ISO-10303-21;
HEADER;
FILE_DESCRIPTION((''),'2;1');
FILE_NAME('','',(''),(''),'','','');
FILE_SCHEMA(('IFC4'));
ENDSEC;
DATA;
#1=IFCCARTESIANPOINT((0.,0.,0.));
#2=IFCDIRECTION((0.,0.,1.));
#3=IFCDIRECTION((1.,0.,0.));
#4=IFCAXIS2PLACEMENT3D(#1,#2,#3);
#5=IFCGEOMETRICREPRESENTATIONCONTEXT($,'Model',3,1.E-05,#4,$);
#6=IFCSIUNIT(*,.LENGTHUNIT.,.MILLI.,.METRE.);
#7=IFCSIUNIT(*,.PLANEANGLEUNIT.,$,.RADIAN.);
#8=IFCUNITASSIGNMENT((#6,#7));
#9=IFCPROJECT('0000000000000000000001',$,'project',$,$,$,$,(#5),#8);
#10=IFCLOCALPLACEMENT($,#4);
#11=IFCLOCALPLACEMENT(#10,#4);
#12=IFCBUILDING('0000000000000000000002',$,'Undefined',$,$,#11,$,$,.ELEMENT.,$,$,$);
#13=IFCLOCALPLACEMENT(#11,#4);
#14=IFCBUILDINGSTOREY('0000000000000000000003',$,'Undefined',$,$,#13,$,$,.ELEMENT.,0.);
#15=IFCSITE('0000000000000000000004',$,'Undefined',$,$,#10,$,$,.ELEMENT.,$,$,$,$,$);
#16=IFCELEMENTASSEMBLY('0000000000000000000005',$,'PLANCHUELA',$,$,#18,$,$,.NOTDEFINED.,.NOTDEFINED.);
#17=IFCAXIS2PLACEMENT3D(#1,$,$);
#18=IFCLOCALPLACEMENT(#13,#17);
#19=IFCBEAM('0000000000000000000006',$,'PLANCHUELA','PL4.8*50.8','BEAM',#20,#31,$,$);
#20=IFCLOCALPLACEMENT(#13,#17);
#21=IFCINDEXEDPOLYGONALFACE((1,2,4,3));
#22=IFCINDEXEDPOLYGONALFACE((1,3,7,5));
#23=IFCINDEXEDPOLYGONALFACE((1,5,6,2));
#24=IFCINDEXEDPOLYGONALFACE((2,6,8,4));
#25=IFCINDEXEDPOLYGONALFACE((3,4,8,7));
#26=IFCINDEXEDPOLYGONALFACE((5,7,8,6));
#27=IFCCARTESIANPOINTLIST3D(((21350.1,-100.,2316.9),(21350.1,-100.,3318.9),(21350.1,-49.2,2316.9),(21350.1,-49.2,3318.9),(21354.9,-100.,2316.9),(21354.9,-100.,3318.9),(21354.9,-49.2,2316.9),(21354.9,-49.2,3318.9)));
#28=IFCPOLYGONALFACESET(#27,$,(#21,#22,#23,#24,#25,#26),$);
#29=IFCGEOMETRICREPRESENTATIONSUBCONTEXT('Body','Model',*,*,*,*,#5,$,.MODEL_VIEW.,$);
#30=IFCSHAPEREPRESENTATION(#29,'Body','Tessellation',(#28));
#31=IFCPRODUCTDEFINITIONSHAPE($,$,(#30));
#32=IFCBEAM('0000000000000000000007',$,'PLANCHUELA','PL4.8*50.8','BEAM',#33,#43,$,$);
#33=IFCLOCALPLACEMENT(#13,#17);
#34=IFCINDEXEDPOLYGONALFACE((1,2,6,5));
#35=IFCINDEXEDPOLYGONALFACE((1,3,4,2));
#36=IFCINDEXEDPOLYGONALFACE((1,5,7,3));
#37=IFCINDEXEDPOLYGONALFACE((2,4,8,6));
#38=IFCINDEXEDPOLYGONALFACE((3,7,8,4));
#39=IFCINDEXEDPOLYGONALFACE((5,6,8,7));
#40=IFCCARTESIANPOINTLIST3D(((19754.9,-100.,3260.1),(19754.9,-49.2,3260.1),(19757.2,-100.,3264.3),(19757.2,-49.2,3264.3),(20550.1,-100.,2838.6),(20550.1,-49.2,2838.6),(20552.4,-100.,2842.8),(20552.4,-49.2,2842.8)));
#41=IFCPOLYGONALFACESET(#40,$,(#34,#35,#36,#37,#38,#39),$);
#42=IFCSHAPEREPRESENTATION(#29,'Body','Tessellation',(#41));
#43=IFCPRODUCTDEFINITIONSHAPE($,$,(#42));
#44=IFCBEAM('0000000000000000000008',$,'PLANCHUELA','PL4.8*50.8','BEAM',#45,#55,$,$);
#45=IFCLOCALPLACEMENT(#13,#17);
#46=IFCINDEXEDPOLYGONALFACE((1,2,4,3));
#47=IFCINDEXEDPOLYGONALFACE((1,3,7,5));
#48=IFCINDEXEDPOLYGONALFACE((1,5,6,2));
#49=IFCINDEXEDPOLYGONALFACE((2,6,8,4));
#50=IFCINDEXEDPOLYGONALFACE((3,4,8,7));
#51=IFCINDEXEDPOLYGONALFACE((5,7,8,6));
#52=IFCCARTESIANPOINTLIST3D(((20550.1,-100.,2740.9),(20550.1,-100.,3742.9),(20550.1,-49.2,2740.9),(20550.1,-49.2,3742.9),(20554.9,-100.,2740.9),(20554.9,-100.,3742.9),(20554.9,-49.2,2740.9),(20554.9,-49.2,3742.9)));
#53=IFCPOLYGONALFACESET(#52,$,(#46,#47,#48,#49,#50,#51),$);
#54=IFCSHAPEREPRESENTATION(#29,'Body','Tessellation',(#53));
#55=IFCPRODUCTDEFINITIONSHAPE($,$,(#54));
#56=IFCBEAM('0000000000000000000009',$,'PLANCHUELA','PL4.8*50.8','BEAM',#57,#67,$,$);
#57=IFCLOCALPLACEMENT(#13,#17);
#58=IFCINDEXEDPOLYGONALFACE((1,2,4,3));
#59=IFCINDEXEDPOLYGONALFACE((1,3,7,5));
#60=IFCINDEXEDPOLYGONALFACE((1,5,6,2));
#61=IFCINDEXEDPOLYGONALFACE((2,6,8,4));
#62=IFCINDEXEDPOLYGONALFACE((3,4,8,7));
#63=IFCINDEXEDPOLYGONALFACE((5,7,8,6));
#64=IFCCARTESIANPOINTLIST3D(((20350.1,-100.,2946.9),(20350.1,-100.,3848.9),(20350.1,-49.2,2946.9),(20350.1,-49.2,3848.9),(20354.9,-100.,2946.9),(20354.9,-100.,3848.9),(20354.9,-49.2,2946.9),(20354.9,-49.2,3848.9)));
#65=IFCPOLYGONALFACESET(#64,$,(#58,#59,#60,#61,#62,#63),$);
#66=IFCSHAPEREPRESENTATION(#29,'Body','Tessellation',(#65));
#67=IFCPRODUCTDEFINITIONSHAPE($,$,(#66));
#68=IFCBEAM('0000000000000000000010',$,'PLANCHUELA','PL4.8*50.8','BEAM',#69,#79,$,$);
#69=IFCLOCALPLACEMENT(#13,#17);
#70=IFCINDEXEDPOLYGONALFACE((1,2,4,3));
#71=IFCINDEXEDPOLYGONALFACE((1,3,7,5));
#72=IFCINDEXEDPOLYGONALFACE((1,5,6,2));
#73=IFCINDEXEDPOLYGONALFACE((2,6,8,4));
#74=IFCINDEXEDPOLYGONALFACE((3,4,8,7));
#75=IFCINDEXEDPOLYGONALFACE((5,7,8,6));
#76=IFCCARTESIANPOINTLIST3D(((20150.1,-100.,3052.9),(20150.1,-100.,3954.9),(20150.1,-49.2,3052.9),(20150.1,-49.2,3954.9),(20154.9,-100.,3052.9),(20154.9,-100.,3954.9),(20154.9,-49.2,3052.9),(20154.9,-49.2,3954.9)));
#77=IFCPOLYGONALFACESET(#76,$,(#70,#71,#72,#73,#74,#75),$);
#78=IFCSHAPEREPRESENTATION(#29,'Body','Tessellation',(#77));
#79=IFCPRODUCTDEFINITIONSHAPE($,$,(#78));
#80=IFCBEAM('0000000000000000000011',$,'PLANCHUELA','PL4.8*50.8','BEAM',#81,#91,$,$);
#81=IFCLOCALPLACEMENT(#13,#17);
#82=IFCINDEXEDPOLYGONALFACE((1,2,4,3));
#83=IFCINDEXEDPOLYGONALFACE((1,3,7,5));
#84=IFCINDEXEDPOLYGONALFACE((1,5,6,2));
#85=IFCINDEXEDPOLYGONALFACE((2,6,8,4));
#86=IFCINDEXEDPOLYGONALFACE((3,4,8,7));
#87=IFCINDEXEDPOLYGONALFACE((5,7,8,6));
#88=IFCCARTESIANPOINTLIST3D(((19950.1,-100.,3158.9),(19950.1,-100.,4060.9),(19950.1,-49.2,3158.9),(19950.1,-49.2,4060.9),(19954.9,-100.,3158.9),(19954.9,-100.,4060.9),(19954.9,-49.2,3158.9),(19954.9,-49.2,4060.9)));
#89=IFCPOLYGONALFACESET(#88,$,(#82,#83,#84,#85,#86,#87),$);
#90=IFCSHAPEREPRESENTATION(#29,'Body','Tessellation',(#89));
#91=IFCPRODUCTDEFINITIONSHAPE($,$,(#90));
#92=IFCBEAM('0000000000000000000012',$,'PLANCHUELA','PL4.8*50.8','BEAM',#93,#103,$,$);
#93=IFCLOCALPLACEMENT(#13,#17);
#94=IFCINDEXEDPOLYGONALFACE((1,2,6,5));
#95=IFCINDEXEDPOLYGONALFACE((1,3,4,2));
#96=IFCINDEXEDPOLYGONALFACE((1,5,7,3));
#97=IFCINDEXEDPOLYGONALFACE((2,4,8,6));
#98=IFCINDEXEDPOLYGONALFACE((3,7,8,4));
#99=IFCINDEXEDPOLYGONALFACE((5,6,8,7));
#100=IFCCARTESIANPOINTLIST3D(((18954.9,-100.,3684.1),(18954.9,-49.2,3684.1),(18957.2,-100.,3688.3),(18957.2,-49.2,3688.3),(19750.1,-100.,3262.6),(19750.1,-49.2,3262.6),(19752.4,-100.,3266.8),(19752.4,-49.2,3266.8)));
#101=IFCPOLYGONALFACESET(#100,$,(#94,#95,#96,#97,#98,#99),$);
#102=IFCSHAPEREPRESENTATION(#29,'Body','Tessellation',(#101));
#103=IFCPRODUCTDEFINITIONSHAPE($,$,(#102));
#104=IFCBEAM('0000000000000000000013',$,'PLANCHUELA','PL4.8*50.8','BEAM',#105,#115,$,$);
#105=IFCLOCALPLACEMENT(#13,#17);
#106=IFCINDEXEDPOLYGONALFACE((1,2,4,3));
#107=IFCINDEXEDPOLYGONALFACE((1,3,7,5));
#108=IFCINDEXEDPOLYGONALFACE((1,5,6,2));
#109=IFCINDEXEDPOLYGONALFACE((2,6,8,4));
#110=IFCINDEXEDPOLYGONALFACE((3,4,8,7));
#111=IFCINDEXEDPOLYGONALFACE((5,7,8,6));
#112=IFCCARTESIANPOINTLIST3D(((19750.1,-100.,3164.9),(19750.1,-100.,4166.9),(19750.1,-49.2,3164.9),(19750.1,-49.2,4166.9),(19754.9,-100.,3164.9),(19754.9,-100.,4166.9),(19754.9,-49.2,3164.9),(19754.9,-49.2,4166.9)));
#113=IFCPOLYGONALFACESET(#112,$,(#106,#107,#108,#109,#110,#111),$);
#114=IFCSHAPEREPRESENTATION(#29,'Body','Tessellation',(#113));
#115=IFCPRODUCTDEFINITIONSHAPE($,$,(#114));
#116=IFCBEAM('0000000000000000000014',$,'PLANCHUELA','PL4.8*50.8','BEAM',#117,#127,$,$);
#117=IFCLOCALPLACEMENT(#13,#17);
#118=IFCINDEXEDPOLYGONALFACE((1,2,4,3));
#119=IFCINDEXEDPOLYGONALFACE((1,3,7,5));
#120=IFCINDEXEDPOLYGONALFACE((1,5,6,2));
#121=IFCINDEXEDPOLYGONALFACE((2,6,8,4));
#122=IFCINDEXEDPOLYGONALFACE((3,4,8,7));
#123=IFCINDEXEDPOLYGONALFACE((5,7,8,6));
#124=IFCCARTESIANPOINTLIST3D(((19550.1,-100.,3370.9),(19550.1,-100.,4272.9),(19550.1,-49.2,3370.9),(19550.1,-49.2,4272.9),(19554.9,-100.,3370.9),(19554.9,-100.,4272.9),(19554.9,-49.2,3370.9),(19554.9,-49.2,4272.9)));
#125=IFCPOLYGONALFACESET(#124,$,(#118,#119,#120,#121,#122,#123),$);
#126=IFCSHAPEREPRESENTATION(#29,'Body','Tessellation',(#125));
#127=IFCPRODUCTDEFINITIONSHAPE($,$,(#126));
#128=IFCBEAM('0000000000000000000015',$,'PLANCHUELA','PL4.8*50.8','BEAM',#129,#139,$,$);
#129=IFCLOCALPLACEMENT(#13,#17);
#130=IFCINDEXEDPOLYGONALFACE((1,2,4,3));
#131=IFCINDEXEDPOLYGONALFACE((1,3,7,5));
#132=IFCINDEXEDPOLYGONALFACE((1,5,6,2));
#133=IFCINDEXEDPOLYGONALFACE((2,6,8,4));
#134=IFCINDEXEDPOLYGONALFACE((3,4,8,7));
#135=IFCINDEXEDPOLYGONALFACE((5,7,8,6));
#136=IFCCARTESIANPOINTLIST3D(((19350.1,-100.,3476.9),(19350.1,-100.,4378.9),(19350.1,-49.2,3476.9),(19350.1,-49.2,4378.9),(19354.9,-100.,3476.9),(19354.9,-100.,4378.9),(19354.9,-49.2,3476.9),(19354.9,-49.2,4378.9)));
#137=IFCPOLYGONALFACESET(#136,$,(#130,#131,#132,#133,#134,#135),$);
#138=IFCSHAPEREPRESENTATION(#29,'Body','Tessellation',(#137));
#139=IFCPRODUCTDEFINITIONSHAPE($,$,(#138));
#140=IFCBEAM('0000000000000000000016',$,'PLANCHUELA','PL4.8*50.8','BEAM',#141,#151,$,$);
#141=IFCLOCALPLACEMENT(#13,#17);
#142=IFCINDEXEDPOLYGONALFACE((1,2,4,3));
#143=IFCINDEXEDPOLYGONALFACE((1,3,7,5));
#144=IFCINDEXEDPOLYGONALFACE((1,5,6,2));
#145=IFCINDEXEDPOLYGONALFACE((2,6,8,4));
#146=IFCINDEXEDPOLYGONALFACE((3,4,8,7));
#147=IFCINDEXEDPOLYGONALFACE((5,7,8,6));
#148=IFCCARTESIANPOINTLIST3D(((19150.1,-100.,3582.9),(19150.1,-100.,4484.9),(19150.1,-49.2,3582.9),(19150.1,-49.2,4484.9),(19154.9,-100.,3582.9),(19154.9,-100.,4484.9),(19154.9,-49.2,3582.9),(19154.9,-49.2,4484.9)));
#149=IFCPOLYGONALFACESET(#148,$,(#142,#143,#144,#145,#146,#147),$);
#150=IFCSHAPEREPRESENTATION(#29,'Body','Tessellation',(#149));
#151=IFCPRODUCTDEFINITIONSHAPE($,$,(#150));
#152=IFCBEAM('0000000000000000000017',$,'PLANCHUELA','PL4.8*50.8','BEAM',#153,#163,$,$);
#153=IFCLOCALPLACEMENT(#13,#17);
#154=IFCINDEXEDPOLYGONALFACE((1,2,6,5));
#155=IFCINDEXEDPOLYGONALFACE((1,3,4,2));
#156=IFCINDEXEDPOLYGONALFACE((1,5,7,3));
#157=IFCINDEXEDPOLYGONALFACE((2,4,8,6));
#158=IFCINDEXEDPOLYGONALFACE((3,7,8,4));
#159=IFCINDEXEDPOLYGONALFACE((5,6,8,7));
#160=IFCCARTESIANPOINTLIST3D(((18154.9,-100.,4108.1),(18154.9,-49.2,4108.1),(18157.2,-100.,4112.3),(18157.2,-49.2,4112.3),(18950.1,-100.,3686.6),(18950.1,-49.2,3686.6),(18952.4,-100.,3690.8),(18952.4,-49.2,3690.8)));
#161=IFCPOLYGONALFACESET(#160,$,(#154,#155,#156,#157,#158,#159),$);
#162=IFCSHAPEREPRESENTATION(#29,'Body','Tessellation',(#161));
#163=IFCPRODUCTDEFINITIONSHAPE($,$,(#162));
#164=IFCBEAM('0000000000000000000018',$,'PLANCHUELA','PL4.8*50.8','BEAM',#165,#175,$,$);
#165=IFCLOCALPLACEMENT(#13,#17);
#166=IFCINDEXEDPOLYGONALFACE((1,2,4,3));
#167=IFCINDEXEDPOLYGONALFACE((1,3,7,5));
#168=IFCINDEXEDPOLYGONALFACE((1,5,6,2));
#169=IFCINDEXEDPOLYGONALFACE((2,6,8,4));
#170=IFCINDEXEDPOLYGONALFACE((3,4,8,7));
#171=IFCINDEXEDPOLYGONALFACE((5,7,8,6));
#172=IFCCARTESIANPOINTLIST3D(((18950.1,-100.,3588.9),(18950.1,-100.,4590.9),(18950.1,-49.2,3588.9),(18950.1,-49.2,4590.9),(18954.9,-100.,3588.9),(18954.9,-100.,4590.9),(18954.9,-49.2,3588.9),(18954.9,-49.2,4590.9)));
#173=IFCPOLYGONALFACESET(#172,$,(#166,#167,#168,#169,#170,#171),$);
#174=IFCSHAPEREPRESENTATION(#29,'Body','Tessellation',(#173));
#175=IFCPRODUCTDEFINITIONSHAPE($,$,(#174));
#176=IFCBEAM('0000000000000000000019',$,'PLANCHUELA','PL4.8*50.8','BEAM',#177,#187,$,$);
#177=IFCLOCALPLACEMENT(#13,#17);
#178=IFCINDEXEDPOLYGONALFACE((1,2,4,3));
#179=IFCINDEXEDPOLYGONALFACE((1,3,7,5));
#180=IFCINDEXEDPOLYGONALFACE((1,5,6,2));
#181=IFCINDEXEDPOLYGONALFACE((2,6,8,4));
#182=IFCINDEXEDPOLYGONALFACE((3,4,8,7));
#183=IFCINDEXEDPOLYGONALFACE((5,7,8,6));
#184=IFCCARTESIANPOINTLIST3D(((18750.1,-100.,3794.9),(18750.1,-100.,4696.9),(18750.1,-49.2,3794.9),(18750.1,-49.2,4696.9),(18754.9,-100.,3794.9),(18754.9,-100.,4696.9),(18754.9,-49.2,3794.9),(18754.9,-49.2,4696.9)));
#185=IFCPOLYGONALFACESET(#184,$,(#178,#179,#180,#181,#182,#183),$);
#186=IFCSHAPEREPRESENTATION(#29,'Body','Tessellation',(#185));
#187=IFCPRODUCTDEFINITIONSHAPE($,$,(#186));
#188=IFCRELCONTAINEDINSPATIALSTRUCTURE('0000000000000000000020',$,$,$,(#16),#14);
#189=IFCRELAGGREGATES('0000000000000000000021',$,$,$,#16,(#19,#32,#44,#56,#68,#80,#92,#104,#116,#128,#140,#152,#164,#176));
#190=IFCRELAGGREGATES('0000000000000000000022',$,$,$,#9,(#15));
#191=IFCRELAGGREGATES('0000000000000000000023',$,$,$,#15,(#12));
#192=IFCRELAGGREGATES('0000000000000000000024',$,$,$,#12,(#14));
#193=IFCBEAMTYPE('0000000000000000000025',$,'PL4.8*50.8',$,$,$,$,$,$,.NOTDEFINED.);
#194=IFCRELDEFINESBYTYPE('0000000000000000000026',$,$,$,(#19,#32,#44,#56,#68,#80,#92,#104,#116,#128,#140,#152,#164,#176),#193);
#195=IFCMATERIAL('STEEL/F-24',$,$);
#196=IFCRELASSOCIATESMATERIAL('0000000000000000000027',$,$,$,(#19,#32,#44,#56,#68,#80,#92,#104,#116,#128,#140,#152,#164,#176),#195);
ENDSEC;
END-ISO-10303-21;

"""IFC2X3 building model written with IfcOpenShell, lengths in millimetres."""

from ifc_helpers import new_model, si_unit, frame, origin_with_axes, origin_2d_with_axis, place, context, subcontext, project, spatial, rectangle, extrude, material, type_object, element, aggregate, save


model = new_model("IFC2X3")

# Units and contexts
model_context = context("Model", 3, precision=1e-05, world=origin_with_axes())
body_context = subcontext(model_context, "Body", "Model", "MODEL_VIEW")
ifc_project = project(units=[si_unit("LENGTHUNIT", "METRE", prefix="MILLI"), si_unit("PLANEANGLEUNIT", "RADIAN")], contexts=[model_context])

# Site, building, storey
site_placement = place(None, origin_with_axes())
site = spatial("IfcSite", under=ifc_project, at=site_placement, Name="Undefined", CompositionType="ELEMENT")
building_placement = place(site_placement, origin_with_axes())
building = spatial("IfcBuilding", under=site, at=building_placement, Name="Undefined", CompositionType="ELEMENT")
storey_placement = place(building_placement, origin_with_axes())
storey = spatial("IfcBuildingStorey", under=building, at=storey_placement, Name="Undefined", CompositionType="ELEMENT", Elevation=0.0)

# Element assembly, beams
assembly_1_placement = place(storey_placement, origin_with_axes())
assembly_1 = element("IfcElementAssembly", 1, at=assembly_1_placement, inside=storey, Name="PLANCHUELA", AssemblyPlace="NOTDEFINED", PredefinedType="NOTDEFINED")
ifc_material_1 = material(Name="STEEL/F-24")
beam_type = type_object("IfcBeamType", Name="PL4.8*50.8", PredefinedType="NOTDEFINED")
beam_1_placement = place(assembly_1_placement, frame((21352.5, -74.6, 3318.9), z_axis=(0.0, 1.0, 0.0), x_axis=(0.0, 0.0, -1.0)))
beam_1 = element("IfcBeam", 2, at=beam_1_placement, type_object=beam_type, material=ifc_material_1, Name="PLANCHUELA", Description="PL4.8*50.8", ObjectType="BEAM", context=body_context, shape_type="SweptSolid", body=[
    extrude(rectangle(XDim=4.8, YDim=50.8, at=origin_2d_with_axis()), frame((1002.0, 0.0, 0.0), z_axis=(-1.0, 0.0, 0.0), x_axis=(0.0, -1.0, 0.0)), (0.0, 0.0, 1.0), 1002.0),
])
beam_2_placement = place(assembly_1_placement, frame((19756.0, -74.6, 3262.2), z_axis=(0.0, 1.0, 0.0), x_axis=(0.883573, 0.0, -0.468294)))
beam_2 = element("IfcBeam", 3, at=beam_2_placement, type_object=beam_type, material=ifc_material_1, Name="PLANCHUELA", Description="PL4.8*50.8", ObjectType="BEAM", context=body_context, shape_type="SweptSolid", body=[
    extrude(rectangle(XDim=4.8, YDim=50.8, at=origin_2d_with_axis()), frame((900.0, 0.0, 0.0), z_axis=(-1.0, 0.0, 0.0), x_axis=(0.0, -1.0, 0.0)), (0.0, 0.0, 1.0), 900.0),
])
beam_3_placement = place(assembly_1_placement, frame((20552.5, -74.6, 3742.9), z_axis=(0.0, 1.0, 0.0), x_axis=(0.0, 0.0, -1.0)))
beam_3 = element("IfcBeam", 4, at=beam_3_placement, type_object=beam_type, material=ifc_material_1, Name="PLANCHUELA", Description="PL4.8*50.8", ObjectType="BEAM", context=body_context, shape_type="SweptSolid", body=[
    extrude(rectangle(XDim=4.8, YDim=50.8, at=origin_2d_with_axis()), frame((1002.0, 0.0, 0.0), z_axis=(-1.0, 0.0, 0.0), x_axis=(0.0, -1.0, 0.0)), (0.0, 0.0, 1.0), 1002.0),
])
beam_4_placement = place(assembly_1_placement, frame((20352.5, -74.6, 3848.9), z_axis=(0.0, 1.0, 0.0), x_axis=(0.0, 0.0, -1.0)))
beam_4 = element("IfcBeam", 5, at=beam_4_placement, type_object=beam_type, material=ifc_material_1, Name="PLANCHUELA", Description="PL4.8*50.8", ObjectType="BEAM", context=body_context, shape_type="SweptSolid", body=[
    extrude(rectangle(XDim=4.8, YDim=50.8, at=origin_2d_with_axis()), frame((902.0, 0.0, 0.0), z_axis=(-1.0, 0.0, 0.0), x_axis=(0.0, -1.0, 0.0)), (0.0, 0.0, 1.0), 902.0),
])
beam_5_placement = place(assembly_1_placement, frame((20152.5, -74.6, 3954.9), z_axis=(0.0, 1.0, 0.0), x_axis=(0.0, 0.0, -1.0)))
beam_5 = element("IfcBeam", 6, at=beam_5_placement, type_object=beam_type, material=ifc_material_1, Name="PLANCHUELA", Description="PL4.8*50.8", ObjectType="BEAM", context=body_context, shape_type="SweptSolid", body=[
    extrude(rectangle(XDim=4.8, YDim=50.8, at=origin_2d_with_axis()), frame((902.0, 0.0, 0.0), z_axis=(-1.0, 0.0, 0.0), x_axis=(0.0, -1.0, 0.0)), (0.0, 0.0, 1.0), 902.0),
])
beam_6_placement = place(assembly_1_placement, frame((19952.5, -74.6, 4060.9), z_axis=(0.0, 1.0, 0.0), x_axis=(0.0, 0.0, -1.0)))
beam_6 = element("IfcBeam", 7, at=beam_6_placement, type_object=beam_type, material=ifc_material_1, Name="PLANCHUELA", Description="PL4.8*50.8", ObjectType="BEAM", context=body_context, shape_type="SweptSolid", body=[
    extrude(rectangle(XDim=4.8, YDim=50.8, at=origin_2d_with_axis()), frame((902.0, 0.0, 0.0), z_axis=(-1.0, 0.0, 0.0), x_axis=(0.0, -1.0, 0.0)), (0.0, 0.0, 1.0), 902.0),
])
beam_7_placement = place(assembly_1_placement, frame((18956.0, -74.6, 3686.2), z_axis=(0.0, 1.0, 0.0), x_axis=(0.883573, 0.0, -0.468294)))
beam_7 = element("IfcBeam", 8, at=beam_7_placement, type_object=beam_type, material=ifc_material_1, Name="PLANCHUELA", Description="PL4.8*50.8", ObjectType="BEAM", context=body_context, shape_type="SweptSolid", body=[
    extrude(rectangle(XDim=4.8, YDim=50.8, at=origin_2d_with_axis()), frame((900.0, 0.0, 0.0), z_axis=(-1.0, 0.0, 0.0), x_axis=(0.0, -1.0, 0.0)), (0.0, 0.0, 1.0), 900.0),
])
beam_8_placement = place(assembly_1_placement, frame((19752.5, -74.6, 4166.9), z_axis=(0.0, 1.0, 0.0), x_axis=(0.0, 0.0, -1.0)))
beam_8 = element("IfcBeam", 9, at=beam_8_placement, type_object=beam_type, material=ifc_material_1, Name="PLANCHUELA", Description="PL4.8*50.8", ObjectType="BEAM", context=body_context, shape_type="SweptSolid", body=[
    extrude(rectangle(XDim=4.8, YDim=50.8, at=origin_2d_with_axis()), frame((1002.0, 0.0, 0.0), z_axis=(-1.0, 0.0, 0.0), x_axis=(0.0, -1.0, 0.0)), (0.0, 0.0, 1.0), 1002.0),
])
beam_9_placement = place(assembly_1_placement, frame((19552.5, -74.6, 4272.9), z_axis=(0.0, 1.0, 0.0), x_axis=(0.0, 0.0, -1.0)))
beam_9 = element("IfcBeam", 10, at=beam_9_placement, type_object=beam_type, material=ifc_material_1, Name="PLANCHUELA", Description="PL4.8*50.8", ObjectType="BEAM", context=body_context, shape_type="SweptSolid", body=[
    extrude(rectangle(XDim=4.8, YDim=50.8, at=origin_2d_with_axis()), frame((902.0, 0.0, 0.0), z_axis=(-1.0, 0.0, 0.0), x_axis=(0.0, -1.0, 0.0)), (0.0, 0.0, 1.0), 902.0),
])
beam_10_placement = place(assembly_1_placement, frame((19352.5, -74.6, 4378.9), z_axis=(0.0, 1.0, 0.0), x_axis=(0.0, 0.0, -1.0)))
beam_10 = element("IfcBeam", 11, at=beam_10_placement, type_object=beam_type, material=ifc_material_1, Name="PLANCHUELA", Description="PL4.8*50.8", ObjectType="BEAM", context=body_context, shape_type="SweptSolid", body=[
    extrude(rectangle(XDim=4.8, YDim=50.8, at=origin_2d_with_axis()), frame((902.0, 0.0, 0.0), z_axis=(-1.0, 0.0, 0.0), x_axis=(0.0, -1.0, 0.0)), (0.0, 0.0, 1.0), 902.0),
])
beam_11_placement = place(assembly_1_placement, frame((19152.5, -74.6, 4484.9), z_axis=(0.0, 1.0, 0.0), x_axis=(0.0, 0.0, -1.0)))
beam_11 = element("IfcBeam", 12, at=beam_11_placement, type_object=beam_type, material=ifc_material_1, Name="PLANCHUELA", Description="PL4.8*50.8", ObjectType="BEAM", context=body_context, shape_type="SweptSolid", body=[
    extrude(rectangle(XDim=4.8, YDim=50.8, at=origin_2d_with_axis()), frame((902.0, 0.0, 0.0), z_axis=(-1.0, 0.0, 0.0), x_axis=(0.0, -1.0, 0.0)), (0.0, 0.0, 1.0), 902.0),
])
beam_12_placement = place(assembly_1_placement, frame((18156.0, -74.6, 4110.2), z_axis=(0.0, 1.0, 0.0), x_axis=(0.883573, 0.0, -0.468294)))
beam_12 = element("IfcBeam", 13, at=beam_12_placement, type_object=beam_type, material=ifc_material_1, Name="PLANCHUELA", Description="PL4.8*50.8", ObjectType="BEAM", context=body_context, shape_type="SweptSolid", body=[
    extrude(rectangle(XDim=4.8, YDim=50.8, at=origin_2d_with_axis()), frame((900.0, 0.0, 0.0), z_axis=(-1.0, 0.0, 0.0), x_axis=(0.0, -1.0, 0.0)), (0.0, 0.0, 1.0), 900.0),
])
beam_13_placement = place(assembly_1_placement, frame((18952.5, -74.6, 4590.9), z_axis=(0.0, 1.0, 0.0), x_axis=(0.0, 0.0, -1.0)))
beam_13 = element("IfcBeam", 14, at=beam_13_placement, type_object=beam_type, material=ifc_material_1, Name="PLANCHUELA", Description="PL4.8*50.8", ObjectType="BEAM", context=body_context, shape_type="SweptSolid", body=[
    extrude(rectangle(XDim=4.8, YDim=50.8, at=origin_2d_with_axis()), frame((1002.0, 0.0, 0.0), z_axis=(-1.0, 0.0, 0.0), x_axis=(0.0, -1.0, 0.0)), (0.0, 0.0, 1.0), 1002.0),
])
beam_14_placement = place(assembly_1_placement, frame((18752.5, -74.6, 4696.9), z_axis=(0.0, 1.0, 0.0), x_axis=(0.0, 0.0, -1.0)))
beam_14 = element("IfcBeam", 15, at=beam_14_placement, type_object=beam_type, material=ifc_material_1, Name="PLANCHUELA", Description="PL4.8*50.8", ObjectType="BEAM", context=body_context, shape_type="SweptSolid", body=[
    extrude(rectangle(XDim=4.8, YDim=50.8, at=origin_2d_with_axis()), frame((902.0, 0.0, 0.0), z_axis=(-1.0, 0.0, 0.0), x_axis=(0.0, -1.0, 0.0)), (0.0, 0.0, 1.0), 902.0),
])

aggregate(assembly_1, [beam_1, beam_2, beam_3, beam_4, beam_5, beam_6, beam_7, beam_8, beam_9, beam_10, beam_11, beam_12, beam_13, beam_14])

save(model, "model.ifc")
